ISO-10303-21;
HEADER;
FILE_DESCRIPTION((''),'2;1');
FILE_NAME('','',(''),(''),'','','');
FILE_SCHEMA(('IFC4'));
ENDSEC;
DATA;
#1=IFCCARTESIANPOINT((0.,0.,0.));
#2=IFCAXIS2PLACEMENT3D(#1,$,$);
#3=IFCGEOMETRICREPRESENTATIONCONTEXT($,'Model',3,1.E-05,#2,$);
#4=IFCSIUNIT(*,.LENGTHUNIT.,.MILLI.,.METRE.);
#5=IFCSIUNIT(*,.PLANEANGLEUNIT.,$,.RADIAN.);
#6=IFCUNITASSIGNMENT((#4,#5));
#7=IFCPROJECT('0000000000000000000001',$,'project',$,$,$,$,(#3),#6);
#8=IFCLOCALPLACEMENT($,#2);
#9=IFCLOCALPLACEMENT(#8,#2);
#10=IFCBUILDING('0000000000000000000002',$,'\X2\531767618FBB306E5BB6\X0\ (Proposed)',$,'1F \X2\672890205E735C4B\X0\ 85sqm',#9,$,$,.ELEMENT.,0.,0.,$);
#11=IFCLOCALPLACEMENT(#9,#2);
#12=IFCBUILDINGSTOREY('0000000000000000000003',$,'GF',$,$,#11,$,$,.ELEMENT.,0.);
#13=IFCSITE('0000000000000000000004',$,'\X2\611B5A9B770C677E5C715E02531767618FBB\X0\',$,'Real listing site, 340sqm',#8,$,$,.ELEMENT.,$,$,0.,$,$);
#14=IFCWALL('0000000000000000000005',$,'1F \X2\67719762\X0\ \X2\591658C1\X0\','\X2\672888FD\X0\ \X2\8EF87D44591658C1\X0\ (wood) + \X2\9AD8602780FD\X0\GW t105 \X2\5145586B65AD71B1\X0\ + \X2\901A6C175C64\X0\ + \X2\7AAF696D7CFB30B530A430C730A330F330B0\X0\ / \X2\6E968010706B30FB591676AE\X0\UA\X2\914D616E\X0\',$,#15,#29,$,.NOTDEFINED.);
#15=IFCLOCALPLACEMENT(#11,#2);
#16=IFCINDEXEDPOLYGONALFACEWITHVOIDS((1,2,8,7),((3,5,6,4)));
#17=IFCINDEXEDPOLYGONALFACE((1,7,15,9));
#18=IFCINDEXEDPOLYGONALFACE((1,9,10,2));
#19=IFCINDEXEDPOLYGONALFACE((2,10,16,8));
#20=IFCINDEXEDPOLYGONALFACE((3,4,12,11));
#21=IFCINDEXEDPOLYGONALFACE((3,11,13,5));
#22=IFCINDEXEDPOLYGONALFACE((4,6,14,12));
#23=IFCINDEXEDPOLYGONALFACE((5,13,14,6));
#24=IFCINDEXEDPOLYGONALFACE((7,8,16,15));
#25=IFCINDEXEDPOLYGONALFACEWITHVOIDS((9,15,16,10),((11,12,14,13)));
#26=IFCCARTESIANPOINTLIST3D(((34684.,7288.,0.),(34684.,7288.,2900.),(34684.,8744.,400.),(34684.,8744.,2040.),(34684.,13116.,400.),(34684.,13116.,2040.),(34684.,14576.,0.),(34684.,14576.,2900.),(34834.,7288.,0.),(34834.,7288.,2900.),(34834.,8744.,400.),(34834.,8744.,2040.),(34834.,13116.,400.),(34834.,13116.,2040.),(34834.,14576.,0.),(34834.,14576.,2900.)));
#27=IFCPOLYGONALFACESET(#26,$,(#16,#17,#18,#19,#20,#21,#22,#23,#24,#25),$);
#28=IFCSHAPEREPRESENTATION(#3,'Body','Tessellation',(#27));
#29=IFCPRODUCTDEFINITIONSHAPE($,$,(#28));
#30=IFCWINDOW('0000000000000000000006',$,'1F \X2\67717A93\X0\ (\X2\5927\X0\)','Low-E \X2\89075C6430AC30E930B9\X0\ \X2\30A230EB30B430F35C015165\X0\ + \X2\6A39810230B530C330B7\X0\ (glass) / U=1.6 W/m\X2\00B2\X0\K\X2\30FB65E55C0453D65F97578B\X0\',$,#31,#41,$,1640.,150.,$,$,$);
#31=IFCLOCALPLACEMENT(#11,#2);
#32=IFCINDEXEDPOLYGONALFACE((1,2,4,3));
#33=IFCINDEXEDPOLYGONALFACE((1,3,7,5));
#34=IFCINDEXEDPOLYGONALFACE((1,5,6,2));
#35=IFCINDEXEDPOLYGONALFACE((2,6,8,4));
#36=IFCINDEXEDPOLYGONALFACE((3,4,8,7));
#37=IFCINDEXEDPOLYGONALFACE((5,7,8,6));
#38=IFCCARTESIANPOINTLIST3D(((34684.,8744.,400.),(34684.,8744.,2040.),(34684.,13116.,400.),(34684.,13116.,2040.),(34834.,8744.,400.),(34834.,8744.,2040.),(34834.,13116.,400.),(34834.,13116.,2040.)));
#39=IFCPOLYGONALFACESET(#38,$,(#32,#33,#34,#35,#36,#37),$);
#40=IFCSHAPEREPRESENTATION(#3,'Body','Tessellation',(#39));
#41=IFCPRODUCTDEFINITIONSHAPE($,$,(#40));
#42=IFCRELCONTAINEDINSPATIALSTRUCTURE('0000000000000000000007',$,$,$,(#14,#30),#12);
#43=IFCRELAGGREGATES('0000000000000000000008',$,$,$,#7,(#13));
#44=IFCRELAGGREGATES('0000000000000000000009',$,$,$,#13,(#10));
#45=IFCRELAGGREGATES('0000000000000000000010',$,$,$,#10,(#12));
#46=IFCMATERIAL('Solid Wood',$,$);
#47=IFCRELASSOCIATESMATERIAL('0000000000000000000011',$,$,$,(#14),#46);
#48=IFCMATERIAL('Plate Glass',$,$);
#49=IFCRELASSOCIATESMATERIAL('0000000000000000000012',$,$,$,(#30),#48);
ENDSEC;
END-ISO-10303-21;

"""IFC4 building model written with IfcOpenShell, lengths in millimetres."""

from ifc_helpers import new_model, si_unit, frame, frame_2d, origin, place, context, project, spatial, rectangle, extrude, material, element, fill, save


model = new_model("IFC4")

# Units and contexts
model_context = context("Model", 3, precision=1e-05, world=origin())
ifc_project = project(units=[si_unit("LENGTHUNIT", "METRE", prefix="MILLI"), si_unit("PLANEANGLEUNIT", "RADIAN")], contexts=[model_context])

# Site, building, storey
site_placement = place(None, origin())
site = spatial("IfcSite", under=ifc_project, at=site_placement, Name="愛媛県松山市北条辻", ObjectType="Real listing site, 340sqm", CompositionType="ELEMENT", RefElevation=0.0)
building_placement = place(site_placement, origin())
building = spatial("IfcBuilding", under=site, at=building_placement, Name="北条辻の家 (Proposed)", ObjectType="1F 木造平屋 85sqm", CompositionType="ELEMENT", ElevationOfRefHeight=0.0, ElevationOfTerrain=0.0)
storey_placement = place(building_placement, origin())
storey = spatial("IfcBuildingStorey", under=building, at=storey_placement, Name="GF", CompositionType="ELEMENT", Elevation=0.0)

# Wall, opening, window
ifc_material_1 = material(Name="Solid Wood")
wall_1_placement = place(storey_placement, frame((17342.0, 3644.0, 0.0)))
wall_1 = element("IfcWall", 1, at=wall_1_placement, inside=storey, material=ifc_material_1, Name="1F 東面 外壁", Description="木製 軸組外壁 (wood) + 高性能GW t105 充填断熱 + 通気層 + 窯業系サイディング / 準耐火・外皮UA配慮", PredefinedType="NOTDEFINED", context=model_context, shape_type="SweptSolid", body=[
    extrude(rectangle(XDim=150.0, YDim=7288.0, at=frame_2d((75.0, 3644.0))), frame((17342.0, 3644.0, 0.0)), (0.0, 0.0, 1.0), 2900.0),
])
opening_placement = place(storey_placement, frame((17342.0, 4372.0, 200.0)))
opening = element("IfcOpeningElement", 2, at=opening_placement, cuts=wall_1, PredefinedType="NOTDEFINED", context=model_context, shape_type="SweptSolid", body=[
    extrude(rectangle(XDim=150.0, YDim=4372.0, at=frame_2d((75.0, 2186.0))), frame((17342.0, 4372.0, 200.0)), (0.0, 0.0, 1.0), 1640.0),
])
ifc_material_2 = material(Name="Plate Glass")
window_1_placement = place(storey_placement, frame((17342.0, 4372.0, 200.0)))
window_1 = element("IfcWindow", 3, at=window_1_placement, inside=storey, material=ifc_material_2, Name="1F 東窓 (大)", Description="Low-E 複層ガラス アルゴン封入 + 樹脂サッシ (glass) / U=1.6 W/m²K・日射取得型", OverallHeight=1640.0, OverallWidth=150.0, context=model_context, shape_type="SweptSolid", body=[
    extrude(rectangle(XDim=150.0, YDim=4372.0, at=frame_2d((75.0, 2186.0))), frame((17342.0, 4372.0, 200.0)), (0.0, 0.0, 1.0), 1640.0),
])
fill(opening, window_1)

save(model, "model.ifc")
